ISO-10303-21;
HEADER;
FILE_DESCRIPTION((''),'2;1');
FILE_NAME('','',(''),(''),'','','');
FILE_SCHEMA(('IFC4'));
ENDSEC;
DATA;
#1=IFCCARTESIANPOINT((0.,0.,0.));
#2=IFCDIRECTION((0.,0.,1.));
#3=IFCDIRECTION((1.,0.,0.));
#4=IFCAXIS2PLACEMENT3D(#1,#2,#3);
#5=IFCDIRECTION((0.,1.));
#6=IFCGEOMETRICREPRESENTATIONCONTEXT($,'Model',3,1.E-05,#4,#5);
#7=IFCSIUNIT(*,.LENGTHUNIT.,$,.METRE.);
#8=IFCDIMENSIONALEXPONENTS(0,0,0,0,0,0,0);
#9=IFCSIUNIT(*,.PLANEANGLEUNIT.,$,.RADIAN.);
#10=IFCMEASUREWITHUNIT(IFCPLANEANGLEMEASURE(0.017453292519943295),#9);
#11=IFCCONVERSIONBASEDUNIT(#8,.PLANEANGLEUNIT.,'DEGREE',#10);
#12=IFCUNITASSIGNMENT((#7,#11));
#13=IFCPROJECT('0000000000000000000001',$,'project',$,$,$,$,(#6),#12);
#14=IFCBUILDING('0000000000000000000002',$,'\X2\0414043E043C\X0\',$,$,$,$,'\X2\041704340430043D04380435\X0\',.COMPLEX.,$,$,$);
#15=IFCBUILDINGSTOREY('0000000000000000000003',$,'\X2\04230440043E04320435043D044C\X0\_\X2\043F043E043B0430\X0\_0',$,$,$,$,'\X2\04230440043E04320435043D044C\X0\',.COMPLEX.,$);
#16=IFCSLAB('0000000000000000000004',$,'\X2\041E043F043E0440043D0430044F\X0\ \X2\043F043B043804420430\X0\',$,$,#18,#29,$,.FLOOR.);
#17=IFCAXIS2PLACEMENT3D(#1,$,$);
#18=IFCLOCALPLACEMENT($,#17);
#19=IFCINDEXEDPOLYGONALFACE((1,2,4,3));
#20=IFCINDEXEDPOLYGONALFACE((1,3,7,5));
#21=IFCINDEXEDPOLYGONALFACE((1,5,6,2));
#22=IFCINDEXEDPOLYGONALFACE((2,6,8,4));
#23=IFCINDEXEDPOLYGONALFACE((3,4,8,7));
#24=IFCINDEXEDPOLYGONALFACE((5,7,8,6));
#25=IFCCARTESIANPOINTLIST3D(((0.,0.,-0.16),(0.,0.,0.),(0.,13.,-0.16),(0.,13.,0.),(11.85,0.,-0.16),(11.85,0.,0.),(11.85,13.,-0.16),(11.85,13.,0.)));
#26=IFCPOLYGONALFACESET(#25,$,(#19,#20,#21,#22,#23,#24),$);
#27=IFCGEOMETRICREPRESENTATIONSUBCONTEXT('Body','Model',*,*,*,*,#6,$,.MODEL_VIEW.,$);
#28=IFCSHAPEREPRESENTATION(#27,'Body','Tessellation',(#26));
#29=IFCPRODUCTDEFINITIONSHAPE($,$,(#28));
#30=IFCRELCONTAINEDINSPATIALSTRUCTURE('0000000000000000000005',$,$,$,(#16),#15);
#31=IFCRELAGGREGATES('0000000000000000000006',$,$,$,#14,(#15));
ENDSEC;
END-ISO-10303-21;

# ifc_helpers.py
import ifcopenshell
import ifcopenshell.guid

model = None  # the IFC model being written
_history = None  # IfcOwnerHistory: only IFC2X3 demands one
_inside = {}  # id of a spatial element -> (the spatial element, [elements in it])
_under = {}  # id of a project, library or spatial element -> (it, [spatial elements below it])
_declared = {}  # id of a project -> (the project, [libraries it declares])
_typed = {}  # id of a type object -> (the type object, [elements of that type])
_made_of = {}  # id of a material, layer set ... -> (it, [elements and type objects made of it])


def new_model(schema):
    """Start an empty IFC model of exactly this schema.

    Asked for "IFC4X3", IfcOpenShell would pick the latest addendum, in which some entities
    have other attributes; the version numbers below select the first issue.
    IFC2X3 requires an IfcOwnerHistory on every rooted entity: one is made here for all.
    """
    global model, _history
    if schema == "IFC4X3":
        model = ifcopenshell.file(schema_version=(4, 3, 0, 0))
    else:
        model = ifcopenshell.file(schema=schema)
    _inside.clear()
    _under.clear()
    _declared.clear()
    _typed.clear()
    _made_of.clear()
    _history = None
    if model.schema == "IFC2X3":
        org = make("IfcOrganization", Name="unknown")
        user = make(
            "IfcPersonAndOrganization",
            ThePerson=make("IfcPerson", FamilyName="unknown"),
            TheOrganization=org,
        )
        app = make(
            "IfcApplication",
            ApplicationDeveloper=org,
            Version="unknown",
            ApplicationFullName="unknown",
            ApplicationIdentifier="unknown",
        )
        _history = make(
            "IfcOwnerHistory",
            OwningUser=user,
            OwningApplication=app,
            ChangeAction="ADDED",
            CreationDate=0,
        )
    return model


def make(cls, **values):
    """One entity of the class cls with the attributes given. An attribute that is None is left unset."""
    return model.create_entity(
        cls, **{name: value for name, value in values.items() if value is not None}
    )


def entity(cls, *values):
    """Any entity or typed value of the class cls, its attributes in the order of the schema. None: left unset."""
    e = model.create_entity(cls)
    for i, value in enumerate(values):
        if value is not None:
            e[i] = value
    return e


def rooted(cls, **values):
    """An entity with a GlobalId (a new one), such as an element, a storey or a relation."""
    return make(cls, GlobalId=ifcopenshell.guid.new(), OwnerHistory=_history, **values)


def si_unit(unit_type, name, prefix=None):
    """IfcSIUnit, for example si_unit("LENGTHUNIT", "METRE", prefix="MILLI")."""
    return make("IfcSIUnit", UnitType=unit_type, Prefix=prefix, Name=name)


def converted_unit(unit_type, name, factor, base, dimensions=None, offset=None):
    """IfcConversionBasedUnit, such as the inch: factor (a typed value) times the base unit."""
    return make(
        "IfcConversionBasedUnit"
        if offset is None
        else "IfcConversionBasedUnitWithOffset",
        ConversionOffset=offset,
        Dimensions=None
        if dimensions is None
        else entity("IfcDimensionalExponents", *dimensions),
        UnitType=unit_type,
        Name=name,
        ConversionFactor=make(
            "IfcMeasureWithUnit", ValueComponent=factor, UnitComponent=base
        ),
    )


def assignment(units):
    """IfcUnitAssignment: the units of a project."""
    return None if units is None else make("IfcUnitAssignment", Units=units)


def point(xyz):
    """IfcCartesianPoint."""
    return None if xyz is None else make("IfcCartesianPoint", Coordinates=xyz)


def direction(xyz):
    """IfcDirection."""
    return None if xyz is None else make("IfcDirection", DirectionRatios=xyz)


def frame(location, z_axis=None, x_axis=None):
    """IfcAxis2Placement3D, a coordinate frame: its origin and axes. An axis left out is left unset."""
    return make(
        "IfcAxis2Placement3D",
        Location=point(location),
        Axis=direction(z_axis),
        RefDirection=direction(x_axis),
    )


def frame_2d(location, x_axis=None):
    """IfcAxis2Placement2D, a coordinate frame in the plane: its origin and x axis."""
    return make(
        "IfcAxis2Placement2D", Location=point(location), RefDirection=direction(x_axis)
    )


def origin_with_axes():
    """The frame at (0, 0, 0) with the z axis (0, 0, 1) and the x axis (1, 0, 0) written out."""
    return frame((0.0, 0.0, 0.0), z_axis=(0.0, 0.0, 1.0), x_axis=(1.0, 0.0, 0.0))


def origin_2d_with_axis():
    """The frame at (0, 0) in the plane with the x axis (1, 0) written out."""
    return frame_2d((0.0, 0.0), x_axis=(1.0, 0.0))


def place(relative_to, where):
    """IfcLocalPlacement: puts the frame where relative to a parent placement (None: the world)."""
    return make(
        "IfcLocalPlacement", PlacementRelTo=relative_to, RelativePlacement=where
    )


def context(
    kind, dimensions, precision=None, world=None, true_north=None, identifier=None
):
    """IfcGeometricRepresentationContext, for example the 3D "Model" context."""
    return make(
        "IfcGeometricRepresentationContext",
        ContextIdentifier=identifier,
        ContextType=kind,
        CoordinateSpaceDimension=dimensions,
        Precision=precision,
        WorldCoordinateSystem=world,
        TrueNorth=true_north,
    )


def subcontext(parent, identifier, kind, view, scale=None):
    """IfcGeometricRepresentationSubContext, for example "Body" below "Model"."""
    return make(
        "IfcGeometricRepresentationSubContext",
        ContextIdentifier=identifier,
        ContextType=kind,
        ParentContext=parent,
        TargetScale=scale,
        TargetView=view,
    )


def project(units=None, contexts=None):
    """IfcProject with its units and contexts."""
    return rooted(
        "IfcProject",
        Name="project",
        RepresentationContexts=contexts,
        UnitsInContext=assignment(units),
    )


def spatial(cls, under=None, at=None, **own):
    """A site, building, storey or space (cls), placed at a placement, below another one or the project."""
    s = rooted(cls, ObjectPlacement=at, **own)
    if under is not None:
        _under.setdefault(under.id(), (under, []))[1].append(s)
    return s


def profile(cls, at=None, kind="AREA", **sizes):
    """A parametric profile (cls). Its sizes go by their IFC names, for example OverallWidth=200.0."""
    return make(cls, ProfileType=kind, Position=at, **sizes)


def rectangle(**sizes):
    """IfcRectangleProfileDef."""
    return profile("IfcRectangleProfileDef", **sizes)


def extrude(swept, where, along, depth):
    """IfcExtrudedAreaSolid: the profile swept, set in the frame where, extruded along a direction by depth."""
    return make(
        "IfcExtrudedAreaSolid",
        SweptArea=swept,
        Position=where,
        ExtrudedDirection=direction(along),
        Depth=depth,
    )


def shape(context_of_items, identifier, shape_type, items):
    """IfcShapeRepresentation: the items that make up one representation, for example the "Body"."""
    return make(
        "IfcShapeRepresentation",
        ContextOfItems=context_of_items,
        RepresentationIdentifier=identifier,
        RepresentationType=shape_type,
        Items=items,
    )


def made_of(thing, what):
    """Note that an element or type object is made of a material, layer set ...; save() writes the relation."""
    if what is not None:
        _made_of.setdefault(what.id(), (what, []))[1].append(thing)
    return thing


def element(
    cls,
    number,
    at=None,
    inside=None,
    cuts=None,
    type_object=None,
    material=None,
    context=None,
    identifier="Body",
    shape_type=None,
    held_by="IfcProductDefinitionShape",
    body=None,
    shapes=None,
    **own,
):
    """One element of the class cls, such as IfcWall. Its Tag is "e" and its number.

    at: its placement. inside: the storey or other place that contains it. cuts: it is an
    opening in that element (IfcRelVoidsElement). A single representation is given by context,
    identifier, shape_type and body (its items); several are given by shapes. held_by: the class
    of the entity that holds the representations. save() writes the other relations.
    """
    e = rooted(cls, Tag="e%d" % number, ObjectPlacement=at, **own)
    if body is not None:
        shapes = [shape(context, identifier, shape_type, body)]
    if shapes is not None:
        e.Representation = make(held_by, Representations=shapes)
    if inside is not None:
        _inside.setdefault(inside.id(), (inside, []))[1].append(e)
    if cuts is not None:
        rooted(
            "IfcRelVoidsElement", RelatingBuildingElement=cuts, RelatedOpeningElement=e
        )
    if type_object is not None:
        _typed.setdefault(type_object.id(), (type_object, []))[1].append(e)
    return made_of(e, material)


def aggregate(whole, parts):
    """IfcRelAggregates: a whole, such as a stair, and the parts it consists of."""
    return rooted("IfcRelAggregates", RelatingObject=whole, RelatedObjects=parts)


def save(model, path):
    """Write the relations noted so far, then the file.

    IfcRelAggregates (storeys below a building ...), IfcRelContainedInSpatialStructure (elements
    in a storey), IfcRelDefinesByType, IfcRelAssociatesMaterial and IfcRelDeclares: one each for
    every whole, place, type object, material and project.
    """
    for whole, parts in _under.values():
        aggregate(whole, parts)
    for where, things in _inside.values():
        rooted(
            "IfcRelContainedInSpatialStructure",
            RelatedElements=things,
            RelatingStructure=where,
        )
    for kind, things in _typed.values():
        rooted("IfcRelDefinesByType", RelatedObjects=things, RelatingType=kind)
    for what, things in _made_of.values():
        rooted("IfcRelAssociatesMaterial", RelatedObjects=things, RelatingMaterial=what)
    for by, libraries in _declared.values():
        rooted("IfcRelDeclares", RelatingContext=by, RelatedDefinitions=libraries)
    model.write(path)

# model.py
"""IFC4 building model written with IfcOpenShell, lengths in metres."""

from ifc_helpers import new_model, entity, si_unit, converted_unit, direction, frame, origin_with_axes, origin_2d_with_axis, place, context, subcontext, project, spatial, rectangle, extrude, element, save


model = new_model("IFC4")

# Units and contexts
model_context = context("Model", 3, precision=1e-05, world=origin_with_axes(), true_north=direction((0.0, 1.0)))
body_context = subcontext(model_context, "Body", "Model", "MODEL_VIEW")
ifc_project = project(units=[si_unit("LENGTHUNIT", "METRE"), converted_unit("PLANEANGLEUNIT", "DEGREE", entity("IfcPlaneAngleMeasure", 0.017453292519943295), si_unit("PLANEANGLEUNIT", "RADIAN"), dimensions=[0, 0, 0, 0, 0, 0, 0])], contexts=[model_context])

# Building, storey
building = spatial("IfcBuilding", Name="Дом", LongName="Здание", CompositionType="COMPLEX")
storey = spatial("IfcBuildingStorey", under=building, Name="Уровень_пола_0", LongName="Уровень", CompositionType="COMPLEX")

# Slab
slab_placement = place(None, origin_with_axes())
element("IfcSlab", 1, at=slab_placement, inside=storey, Name="Опорная плита", PredefinedType="FLOOR", context=body_context, shape_type="SweptSolid", body=[
    extrude(rectangle(XDim=11.85, YDim=13.0, at=origin_2d_with_axis()), frame((5.925, 6.5, 0.0), z_axis=(0.0, 0.0, 1.0), x_axis=(1.0, 0.0, 0.0)), (0.0, 0.0, -1.0), 0.16),
])

save(model, "model.ifc")
